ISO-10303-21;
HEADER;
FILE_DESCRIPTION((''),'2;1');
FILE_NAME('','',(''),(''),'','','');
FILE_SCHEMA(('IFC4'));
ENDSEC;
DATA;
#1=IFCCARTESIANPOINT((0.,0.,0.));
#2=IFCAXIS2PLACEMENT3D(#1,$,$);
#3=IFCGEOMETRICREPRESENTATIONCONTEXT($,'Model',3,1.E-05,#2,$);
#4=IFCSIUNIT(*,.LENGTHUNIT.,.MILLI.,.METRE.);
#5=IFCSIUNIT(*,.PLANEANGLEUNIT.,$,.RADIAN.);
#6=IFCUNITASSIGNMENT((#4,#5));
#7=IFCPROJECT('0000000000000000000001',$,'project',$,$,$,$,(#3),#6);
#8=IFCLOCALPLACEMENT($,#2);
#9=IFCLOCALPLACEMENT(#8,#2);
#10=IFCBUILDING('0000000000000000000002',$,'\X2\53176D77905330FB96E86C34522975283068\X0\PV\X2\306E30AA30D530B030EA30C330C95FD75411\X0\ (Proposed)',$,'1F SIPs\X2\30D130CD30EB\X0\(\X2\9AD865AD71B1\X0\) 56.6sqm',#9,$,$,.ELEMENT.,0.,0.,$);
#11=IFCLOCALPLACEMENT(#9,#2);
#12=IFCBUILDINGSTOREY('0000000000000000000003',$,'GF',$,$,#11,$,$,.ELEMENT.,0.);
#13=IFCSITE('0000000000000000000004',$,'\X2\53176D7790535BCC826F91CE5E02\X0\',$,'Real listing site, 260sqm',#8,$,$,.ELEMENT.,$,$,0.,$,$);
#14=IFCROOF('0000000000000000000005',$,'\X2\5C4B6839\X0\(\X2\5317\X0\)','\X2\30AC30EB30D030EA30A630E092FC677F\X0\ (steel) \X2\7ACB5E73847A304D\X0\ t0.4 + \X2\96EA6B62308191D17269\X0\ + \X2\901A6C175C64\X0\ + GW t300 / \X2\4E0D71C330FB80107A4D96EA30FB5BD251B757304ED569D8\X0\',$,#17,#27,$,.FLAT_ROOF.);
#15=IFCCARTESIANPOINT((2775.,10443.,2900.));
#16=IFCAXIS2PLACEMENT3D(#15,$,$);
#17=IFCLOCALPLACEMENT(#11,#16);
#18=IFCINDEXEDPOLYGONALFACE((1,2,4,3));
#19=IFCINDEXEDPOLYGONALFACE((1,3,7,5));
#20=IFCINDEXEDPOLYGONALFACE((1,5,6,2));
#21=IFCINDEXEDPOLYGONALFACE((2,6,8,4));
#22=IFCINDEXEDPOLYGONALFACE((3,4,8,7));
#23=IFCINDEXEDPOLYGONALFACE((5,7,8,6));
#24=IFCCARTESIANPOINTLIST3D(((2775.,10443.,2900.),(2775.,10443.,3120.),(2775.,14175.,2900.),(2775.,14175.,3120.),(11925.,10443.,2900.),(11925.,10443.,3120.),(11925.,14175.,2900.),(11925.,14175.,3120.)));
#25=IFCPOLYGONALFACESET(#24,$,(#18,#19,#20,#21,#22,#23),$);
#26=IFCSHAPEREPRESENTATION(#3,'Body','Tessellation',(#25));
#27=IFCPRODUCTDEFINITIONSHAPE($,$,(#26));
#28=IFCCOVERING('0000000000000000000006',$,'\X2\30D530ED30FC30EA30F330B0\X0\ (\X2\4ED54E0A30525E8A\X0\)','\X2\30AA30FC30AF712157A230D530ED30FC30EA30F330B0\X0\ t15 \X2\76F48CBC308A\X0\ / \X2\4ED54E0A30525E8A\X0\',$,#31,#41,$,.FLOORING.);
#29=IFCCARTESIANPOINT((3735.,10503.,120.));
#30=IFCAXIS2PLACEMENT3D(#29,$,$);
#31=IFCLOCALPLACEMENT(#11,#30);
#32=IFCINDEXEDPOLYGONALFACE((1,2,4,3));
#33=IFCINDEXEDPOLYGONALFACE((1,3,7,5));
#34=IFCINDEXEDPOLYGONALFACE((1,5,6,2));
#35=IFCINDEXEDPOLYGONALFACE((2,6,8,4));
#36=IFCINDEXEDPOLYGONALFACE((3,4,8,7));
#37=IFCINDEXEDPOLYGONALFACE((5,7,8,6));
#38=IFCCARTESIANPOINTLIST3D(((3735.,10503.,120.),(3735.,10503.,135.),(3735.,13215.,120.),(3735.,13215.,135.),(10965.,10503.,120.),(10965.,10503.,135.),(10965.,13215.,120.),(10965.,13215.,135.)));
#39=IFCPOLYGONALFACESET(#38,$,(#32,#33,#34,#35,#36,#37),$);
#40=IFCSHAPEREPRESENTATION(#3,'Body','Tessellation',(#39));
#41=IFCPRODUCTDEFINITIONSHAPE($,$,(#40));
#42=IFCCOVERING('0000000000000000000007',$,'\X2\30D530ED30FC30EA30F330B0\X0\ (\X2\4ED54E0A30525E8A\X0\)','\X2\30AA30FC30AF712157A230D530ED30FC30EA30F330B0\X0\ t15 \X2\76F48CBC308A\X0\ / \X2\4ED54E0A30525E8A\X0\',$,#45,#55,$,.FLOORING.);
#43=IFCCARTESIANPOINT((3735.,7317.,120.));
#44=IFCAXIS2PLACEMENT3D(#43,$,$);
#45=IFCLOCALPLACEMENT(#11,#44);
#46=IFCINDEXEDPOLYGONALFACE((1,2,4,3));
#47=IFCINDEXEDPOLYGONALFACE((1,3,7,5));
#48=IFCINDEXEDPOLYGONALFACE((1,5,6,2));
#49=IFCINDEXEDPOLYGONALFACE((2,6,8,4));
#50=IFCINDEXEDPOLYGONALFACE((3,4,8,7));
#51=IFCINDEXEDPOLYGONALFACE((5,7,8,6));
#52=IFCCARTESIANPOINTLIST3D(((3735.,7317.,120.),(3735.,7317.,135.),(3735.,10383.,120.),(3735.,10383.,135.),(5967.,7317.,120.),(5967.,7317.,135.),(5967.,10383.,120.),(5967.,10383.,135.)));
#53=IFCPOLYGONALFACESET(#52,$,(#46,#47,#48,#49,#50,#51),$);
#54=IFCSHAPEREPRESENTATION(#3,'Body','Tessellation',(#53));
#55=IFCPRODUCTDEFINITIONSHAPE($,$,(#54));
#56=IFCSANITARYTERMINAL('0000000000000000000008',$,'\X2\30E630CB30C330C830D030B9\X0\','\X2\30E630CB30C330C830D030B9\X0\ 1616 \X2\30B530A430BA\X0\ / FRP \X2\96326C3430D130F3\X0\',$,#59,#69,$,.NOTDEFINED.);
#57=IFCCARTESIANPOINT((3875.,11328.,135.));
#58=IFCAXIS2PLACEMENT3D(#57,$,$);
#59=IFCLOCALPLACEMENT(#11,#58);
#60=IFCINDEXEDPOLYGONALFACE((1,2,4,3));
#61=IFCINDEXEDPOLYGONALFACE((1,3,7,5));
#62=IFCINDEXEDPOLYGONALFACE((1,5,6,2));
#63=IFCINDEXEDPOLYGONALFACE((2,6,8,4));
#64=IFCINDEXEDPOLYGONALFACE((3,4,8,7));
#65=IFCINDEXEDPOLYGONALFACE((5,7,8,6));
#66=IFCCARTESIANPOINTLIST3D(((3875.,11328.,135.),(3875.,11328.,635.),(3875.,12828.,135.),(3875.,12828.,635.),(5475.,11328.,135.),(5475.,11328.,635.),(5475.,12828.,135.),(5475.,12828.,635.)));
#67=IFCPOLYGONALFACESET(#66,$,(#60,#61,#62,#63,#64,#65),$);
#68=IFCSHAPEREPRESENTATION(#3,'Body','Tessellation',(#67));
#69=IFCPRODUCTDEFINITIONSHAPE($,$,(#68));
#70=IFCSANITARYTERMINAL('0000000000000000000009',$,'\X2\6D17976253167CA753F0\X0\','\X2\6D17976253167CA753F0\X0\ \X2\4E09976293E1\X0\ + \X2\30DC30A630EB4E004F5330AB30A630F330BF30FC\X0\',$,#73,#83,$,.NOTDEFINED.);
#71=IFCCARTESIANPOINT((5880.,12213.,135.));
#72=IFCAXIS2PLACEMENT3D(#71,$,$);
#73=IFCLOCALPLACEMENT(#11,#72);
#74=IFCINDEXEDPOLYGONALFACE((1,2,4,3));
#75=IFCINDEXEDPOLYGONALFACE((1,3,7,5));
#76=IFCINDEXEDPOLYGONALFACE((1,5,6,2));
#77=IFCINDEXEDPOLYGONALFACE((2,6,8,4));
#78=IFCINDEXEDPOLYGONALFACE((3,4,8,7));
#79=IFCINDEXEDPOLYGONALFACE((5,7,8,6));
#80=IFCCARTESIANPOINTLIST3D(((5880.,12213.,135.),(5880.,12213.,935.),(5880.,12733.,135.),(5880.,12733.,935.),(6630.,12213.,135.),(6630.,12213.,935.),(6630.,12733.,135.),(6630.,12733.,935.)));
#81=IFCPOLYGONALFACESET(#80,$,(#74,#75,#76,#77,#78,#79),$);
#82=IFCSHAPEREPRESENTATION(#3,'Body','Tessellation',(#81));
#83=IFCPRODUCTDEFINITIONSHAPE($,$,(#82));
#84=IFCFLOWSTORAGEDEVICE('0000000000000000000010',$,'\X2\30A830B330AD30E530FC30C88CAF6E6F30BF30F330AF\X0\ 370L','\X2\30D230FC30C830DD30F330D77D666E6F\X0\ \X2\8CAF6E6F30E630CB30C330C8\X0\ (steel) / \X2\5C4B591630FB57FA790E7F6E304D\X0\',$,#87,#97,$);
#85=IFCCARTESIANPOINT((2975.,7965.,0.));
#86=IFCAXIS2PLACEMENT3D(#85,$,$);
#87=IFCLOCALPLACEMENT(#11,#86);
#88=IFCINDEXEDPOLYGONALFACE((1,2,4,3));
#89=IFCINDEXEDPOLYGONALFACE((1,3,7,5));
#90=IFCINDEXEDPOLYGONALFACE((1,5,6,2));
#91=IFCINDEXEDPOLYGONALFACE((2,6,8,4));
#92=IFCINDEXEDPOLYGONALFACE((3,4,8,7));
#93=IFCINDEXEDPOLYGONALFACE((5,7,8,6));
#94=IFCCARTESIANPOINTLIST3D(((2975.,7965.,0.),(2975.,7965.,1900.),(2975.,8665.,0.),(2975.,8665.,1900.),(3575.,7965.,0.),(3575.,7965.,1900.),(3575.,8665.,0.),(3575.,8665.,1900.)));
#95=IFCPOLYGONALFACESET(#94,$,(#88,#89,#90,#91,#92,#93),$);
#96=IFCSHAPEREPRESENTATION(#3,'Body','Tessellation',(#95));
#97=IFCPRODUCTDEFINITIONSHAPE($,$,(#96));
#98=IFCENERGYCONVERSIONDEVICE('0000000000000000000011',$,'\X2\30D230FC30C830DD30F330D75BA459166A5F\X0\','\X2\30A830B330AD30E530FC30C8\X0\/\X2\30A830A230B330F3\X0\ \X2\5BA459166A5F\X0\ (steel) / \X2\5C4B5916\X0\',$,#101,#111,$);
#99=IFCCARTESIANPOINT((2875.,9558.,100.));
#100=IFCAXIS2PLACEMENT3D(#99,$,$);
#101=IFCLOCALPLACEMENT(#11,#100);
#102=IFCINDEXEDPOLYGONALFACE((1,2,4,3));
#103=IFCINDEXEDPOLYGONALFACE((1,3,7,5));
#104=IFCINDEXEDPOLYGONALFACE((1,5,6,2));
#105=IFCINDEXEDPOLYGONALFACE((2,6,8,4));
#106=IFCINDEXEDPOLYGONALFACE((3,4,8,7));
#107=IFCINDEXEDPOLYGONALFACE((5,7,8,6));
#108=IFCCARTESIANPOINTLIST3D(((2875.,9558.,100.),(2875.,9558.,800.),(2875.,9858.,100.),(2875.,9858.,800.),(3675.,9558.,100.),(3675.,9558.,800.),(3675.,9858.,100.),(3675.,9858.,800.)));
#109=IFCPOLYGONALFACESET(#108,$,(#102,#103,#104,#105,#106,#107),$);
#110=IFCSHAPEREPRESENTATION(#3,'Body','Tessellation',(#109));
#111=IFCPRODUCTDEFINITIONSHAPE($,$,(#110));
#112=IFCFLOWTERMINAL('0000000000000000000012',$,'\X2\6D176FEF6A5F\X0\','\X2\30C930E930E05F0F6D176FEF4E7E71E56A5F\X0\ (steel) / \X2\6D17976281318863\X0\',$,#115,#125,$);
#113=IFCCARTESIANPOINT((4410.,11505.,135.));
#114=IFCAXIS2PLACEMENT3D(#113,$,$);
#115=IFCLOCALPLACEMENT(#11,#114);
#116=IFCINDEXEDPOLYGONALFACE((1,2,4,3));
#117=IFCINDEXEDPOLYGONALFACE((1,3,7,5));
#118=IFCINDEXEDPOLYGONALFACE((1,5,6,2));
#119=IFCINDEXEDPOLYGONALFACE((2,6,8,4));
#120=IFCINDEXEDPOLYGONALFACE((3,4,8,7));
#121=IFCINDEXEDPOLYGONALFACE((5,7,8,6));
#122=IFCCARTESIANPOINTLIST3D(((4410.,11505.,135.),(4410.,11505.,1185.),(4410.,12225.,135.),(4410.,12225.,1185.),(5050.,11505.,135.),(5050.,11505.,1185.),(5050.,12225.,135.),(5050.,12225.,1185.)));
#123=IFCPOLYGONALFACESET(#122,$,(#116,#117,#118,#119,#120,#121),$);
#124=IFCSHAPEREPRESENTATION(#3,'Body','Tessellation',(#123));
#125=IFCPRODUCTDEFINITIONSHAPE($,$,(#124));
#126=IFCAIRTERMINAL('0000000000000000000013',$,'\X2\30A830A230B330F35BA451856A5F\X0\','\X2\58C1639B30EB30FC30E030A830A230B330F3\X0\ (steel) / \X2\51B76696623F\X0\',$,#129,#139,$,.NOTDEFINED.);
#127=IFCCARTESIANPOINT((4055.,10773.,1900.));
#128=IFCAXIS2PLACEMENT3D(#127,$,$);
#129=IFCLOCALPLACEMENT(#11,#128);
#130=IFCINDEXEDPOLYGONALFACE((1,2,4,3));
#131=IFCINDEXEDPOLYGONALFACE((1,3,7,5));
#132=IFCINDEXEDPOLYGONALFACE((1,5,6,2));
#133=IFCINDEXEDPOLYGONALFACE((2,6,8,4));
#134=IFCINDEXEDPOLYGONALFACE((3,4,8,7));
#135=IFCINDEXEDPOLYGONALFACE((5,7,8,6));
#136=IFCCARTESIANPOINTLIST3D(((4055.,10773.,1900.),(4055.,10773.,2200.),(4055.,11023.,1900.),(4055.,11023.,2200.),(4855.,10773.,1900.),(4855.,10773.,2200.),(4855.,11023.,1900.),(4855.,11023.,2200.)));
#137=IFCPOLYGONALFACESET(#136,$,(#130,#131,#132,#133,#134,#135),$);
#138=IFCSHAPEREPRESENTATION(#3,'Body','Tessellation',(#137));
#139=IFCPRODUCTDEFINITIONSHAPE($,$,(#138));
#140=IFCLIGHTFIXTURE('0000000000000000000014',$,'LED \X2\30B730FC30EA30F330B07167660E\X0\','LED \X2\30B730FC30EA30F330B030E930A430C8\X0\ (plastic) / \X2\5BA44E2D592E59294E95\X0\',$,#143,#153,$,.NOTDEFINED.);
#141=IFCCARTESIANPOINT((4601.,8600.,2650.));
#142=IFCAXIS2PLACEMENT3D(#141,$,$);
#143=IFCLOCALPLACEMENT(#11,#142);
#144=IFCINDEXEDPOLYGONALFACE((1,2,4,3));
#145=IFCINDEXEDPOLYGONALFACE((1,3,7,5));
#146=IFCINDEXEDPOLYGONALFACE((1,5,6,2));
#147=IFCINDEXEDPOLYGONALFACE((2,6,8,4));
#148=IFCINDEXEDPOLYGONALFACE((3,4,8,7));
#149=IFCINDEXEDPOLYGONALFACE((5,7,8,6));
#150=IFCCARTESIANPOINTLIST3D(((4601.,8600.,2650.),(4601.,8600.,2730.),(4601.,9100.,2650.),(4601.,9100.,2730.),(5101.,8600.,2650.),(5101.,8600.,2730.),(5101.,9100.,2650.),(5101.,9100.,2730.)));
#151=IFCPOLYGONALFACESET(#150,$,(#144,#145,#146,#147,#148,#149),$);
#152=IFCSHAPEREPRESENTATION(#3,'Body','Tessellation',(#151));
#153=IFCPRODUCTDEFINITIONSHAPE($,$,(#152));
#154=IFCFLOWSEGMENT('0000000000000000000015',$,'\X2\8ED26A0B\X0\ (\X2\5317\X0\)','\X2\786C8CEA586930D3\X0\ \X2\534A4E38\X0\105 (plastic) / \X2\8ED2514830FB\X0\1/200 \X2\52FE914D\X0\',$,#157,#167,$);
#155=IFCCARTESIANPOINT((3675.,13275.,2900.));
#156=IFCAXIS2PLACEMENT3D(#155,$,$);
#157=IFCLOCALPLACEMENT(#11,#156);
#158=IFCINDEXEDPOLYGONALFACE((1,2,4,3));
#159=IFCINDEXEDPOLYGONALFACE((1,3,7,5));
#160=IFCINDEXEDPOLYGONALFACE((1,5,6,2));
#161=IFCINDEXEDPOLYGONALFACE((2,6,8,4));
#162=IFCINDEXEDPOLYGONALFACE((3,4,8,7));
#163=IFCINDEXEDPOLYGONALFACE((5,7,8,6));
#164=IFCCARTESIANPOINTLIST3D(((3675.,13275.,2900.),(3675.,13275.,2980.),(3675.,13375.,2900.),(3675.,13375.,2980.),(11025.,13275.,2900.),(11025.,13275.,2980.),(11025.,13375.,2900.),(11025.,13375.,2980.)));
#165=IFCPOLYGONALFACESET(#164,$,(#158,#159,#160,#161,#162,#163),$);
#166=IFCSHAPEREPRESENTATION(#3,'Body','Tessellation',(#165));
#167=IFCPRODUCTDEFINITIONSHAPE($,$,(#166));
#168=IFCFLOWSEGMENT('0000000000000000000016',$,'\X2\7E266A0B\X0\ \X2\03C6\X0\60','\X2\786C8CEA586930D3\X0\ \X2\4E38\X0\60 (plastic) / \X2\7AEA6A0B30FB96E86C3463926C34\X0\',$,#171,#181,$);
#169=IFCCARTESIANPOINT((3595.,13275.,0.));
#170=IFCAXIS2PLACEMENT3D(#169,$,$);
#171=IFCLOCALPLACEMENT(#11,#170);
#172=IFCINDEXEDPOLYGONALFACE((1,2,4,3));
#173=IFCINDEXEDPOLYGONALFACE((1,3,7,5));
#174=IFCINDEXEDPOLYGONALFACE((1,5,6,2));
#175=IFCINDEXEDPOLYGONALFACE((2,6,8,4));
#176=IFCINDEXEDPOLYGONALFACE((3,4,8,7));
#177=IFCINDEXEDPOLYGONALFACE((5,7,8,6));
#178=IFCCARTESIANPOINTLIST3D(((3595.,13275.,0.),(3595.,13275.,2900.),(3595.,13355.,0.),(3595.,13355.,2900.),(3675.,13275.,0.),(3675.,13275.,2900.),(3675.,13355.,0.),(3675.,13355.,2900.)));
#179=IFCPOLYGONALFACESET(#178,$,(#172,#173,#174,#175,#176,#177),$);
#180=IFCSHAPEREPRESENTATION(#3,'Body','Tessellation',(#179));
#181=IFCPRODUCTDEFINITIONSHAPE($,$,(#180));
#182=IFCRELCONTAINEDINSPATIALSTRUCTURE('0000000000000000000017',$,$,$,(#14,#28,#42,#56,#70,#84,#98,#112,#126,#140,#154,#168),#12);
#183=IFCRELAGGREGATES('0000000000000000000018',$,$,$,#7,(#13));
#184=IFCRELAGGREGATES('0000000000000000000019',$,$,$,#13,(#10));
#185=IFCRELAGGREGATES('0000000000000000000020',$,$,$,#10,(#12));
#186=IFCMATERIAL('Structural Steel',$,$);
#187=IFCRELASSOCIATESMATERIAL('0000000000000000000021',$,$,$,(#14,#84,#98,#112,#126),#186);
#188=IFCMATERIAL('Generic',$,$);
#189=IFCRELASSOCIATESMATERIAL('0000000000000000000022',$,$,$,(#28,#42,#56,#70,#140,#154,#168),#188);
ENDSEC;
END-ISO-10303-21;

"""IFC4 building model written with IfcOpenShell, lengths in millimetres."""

from ifc_helpers import new_model, si_unit, frame, frame_2d, origin, place, context, project, spatial, rectangle, extrude, material, element, save


model = new_model("IFC4")

# Units and contexts
model_context = context("Model", 3, precision=1e-05, world=origin())
ifc_project = project(units=[si_unit("LENGTHUNIT", "METRE", prefix="MILLI"), si_unit("PLANEANGLEUNIT", "RADIAN")], contexts=[model_context])

# Site, building, storey
site_placement = place(None, origin())
site = spatial("IfcSite", under=ifc_project, at=site_placement, Name="北海道富良野市", ObjectType="Real listing site, 260sqm", CompositionType="ELEMENT", RefElevation=0.0)
building_placement = place(site_placement, origin())
building = spatial("IfcBuilding", under=site, at=building_placement, Name="北海道・雨水利用とPVのオフグリッド志向 (Proposed)", ObjectType="1F SIPsパネル(高断熱) 56.6sqm", CompositionType="ELEMENT", ElevationOfRefHeight=0.0, ElevationOfTerrain=0.0)
storey_placement = place(building_placement, origin())
storey = spatial("IfcBuildingStorey", under=building, at=storey_placement, Name="GF", CompositionType="ELEMENT", Elevation=0.0)

# Roof
ifc_material_1 = material(Name="Structural Steel")
roof_placement = place(storey_placement, frame((2775.0, 10443.0, 2900.0)))
element("IfcRoof", 1, at=roof_placement, inside=storey, material=ifc_material_1, Name="屋根(北)", Description="ガルバリウム鋼板 (steel) 立平葺き t0.4 + 雪止め金物 + 通気層 + GW t300 / 不燃・耐積雪・寒冷地仕様", PredefinedType="FLAT_ROOF", context=model_context, shape_type="SweptSolid", body=[
    extrude(rectangle(XDim=9150.0, YDim=3732.0, at=frame_2d((4575.0, 1866.0))), frame((2775.0, 10443.0, 2900.0)), (0.0, 0.0, 1.0), 220.0),
])

# Coverings
ifc_material_2 = material(Name="Generic")
covering_1_placement = place(storey_placement, frame((3735.0, 10503.0, 120.0)))
element("IfcCovering", 2, at=covering_1_placement, inside=storey, material=ifc_material_2, Name="フローリング (仕上げ床)", Description="オーク無垢フローリング t15 直貼り / 仕上げ床", PredefinedType="FLOORING", context=model_context, shape_type="SweptSolid", body=[
    extrude(rectangle(XDim=7230.0, YDim=2712.0, at=frame_2d((3615.0, 1356.0))), frame((3735.0, 10503.0, 120.0)), (0.0, 0.0, 1.0), 15.0),
])
covering_2_placement = place(storey_placement, frame((3735.0, 7317.0, 120.0)))
element("IfcCovering", 3, at=covering_2_placement, inside=storey, material=ifc_material_2, Name="フローリング (仕上げ床)", Description="オーク無垢フローリング t15 直貼り / 仕上げ床", PredefinedType="FLOORING", context=model_context, shape_type="SweptSolid", body=[
    extrude(rectangle(XDim=2232.0, YDim=3066.0, at=frame_2d((1116.0, 1533.0))), frame((3735.0, 7317.0, 120.0)), (0.0, 0.0, 1.0), 15.0),
])

# Sanitary terminals
sanitary_terminal_1_placement = place(storey_placement, frame((3875.0, 11328.0, 135.0)))
element("IfcSanitaryTerminal", 4, at=sanitary_terminal_1_placement, inside=storey, material=ifc_material_2, Name="ユニットバス", Description="ユニットバス 1616 サイズ / FRP 防水パン", PredefinedType="NOTDEFINED", context=model_context, shape_type="SweptSolid", body=[
    extrude(rectangle(XDim=1600.0, YDim=1500.0, at=frame_2d((800.0, 750.0))), frame((3875.0, 11328.0, 135.0)), (0.0, 0.0, 1.0), 500.0),
])
sanitary_terminal_2_placement = place(storey_placement, frame((5880.0, 12213.0, 135.0)))
element("IfcSanitaryTerminal", 5, at=sanitary_terminal_2_placement, inside=storey, material=ifc_material_2, Name="洗面化粧台", Description="洗面化粧台 三面鏡 + ボウル一体カウンター", PredefinedType="NOTDEFINED", context=model_context, shape_type="SweptSolid", body=[
    extrude(rectangle(XDim=750.0, YDim=520.0, at=frame_2d((375.0, 260.0))), frame((5880.0, 12213.0, 135.0)), (0.0, 0.0, 1.0), 800.0),
])

# Flow storage device
flow_storage_device_placement = place(storey_placement, frame((2975.0, 7965.0, 0.0)))
element("IfcFlowStorageDevice", 6, at=flow_storage_device_placement, inside=storey, material=ifc_material_1, Name="エコキュート貯湯タンク 370L", Description="ヒートポンプ給湯 貯湯ユニット (steel) / 屋外・基礎置き", context=model_context, shape_type="SweptSolid", body=[
    extrude(rectangle(XDim=600.0, YDim=700.0, at=frame_2d((300.0, 350.0))), frame((2975.0, 7965.0, 0.0)), (0.0, 0.0, 1.0), 1900.0),
])

# Energy conversion device
energy_conversion_device_placement = place(storey_placement, frame((2875.0, 9558.0, 100.0)))
element("IfcEnergyConversionDevice", 7, at=energy_conversion_device_placement, inside=storey, material=ifc_material_1, Name="ヒートポンプ室外機", Description="エコキュート/エアコン 室外機 (steel) / 屋外", context=model_context, shape_type="SweptSolid", body=[
    extrude(rectangle(XDim=800.0, YDim=300.0, at=frame_2d((400.0, 150.0))), frame((2875.0, 9558.0, 100.0)), (0.0, 0.0, 1.0), 700.0),
])

# Flow terminal
flow_terminal_placement = place(storey_placement, frame((4410.0, 11505.0, 135.0)))
element("IfcFlowTerminal", 8, at=flow_terminal_placement, inside=storey, material=ifc_material_1, Name="洗濯機", Description="ドラム式洗濯乾燥機 (steel) / 洗面脱衣", context=model_context, shape_type="SweptSolid", body=[
    extrude(rectangle(XDim=640.0, YDim=720.0, at=frame_2d((320.0, 360.0))), frame((4410.0, 11505.0, 135.0)), (0.0, 0.0, 1.0), 1050.0),
])

# Air terminal
air_terminal_placement = place(storey_placement, frame((4055.0, 10773.0, 1900.0)))
element("IfcAirTerminal", 9, at=air_terminal_placement, inside=storey, material=ifc_material_1, Name="エアコン室内機", Description="壁掛ルームエアコン (steel) / 冷暖房", PredefinedType="NOTDEFINED", context=model_context, shape_type="SweptSolid", body=[
    extrude(rectangle(XDim=800.0, YDim=250.0, at=frame_2d((400.0, 125.0))), frame((4055.0, 10773.0, 1900.0)), (0.0, 0.0, 1.0), 300.0),
])

# Light fixture
light_fixture_placement = place(storey_placement, frame((4601.0, 8600.0, 2650.0)))
element("IfcLightFixture", 10, at=light_fixture_placement, inside=storey, material=ifc_material_2, Name="LED シーリング照明", Description="LED シーリングライト (plastic) / 室中央天井", PredefinedType="NOTDEFINED", context=model_context, shape_type="SweptSolid", body=[
    extrude(rectangle(XDim=500.0, YDim=500.0, at=frame_2d((250.0, 250.0))), frame((4601.0, 8600.0, 2650.0)), (0.0, 0.0, 1.0), 80.0),
])

# Flow segments
flow_segment_1_placement = place(storey_placement, frame((3675.0, 13275.0, 2900.0)))
element("IfcFlowSegment", 11, at=flow_segment_1_placement, inside=storey, material=ifc_material_2, Name="軒樋 (北)", Description="硬質塩ビ 半丸105 (plastic) / 軒先・1/200 勾配", context=model_context, shape_type="SweptSolid", body=[
    extrude(rectangle(XDim=7350.0, YDim=100.0, at=frame_2d((3675.0, 50.0))), frame((3675.0, 13275.0, 2900.0)), (0.0, 0.0, 1.0), 80.0),
])
flow_segment_2_placement = place(storey_placement, frame((3595.0, 13275.0, 0.0)))
element("IfcFlowSegment", 12, at=flow_segment_2_placement, inside=storey, material=ifc_material_2, Name="縦樋 φ60", Description="硬質塩ビ 丸60 (plastic) / 竪樋・雨水排水", context=model_context, shape_type="SweptSolid", body=[
    extrude(rectangle(XDim=80.0, YDim=80.0, at=frame_2d((40.0, 40.0))), frame((3595.0, 13275.0, 0.0)), (0.0, 0.0, 1.0), 2900.0),
])

save(model, "model.ifc")
